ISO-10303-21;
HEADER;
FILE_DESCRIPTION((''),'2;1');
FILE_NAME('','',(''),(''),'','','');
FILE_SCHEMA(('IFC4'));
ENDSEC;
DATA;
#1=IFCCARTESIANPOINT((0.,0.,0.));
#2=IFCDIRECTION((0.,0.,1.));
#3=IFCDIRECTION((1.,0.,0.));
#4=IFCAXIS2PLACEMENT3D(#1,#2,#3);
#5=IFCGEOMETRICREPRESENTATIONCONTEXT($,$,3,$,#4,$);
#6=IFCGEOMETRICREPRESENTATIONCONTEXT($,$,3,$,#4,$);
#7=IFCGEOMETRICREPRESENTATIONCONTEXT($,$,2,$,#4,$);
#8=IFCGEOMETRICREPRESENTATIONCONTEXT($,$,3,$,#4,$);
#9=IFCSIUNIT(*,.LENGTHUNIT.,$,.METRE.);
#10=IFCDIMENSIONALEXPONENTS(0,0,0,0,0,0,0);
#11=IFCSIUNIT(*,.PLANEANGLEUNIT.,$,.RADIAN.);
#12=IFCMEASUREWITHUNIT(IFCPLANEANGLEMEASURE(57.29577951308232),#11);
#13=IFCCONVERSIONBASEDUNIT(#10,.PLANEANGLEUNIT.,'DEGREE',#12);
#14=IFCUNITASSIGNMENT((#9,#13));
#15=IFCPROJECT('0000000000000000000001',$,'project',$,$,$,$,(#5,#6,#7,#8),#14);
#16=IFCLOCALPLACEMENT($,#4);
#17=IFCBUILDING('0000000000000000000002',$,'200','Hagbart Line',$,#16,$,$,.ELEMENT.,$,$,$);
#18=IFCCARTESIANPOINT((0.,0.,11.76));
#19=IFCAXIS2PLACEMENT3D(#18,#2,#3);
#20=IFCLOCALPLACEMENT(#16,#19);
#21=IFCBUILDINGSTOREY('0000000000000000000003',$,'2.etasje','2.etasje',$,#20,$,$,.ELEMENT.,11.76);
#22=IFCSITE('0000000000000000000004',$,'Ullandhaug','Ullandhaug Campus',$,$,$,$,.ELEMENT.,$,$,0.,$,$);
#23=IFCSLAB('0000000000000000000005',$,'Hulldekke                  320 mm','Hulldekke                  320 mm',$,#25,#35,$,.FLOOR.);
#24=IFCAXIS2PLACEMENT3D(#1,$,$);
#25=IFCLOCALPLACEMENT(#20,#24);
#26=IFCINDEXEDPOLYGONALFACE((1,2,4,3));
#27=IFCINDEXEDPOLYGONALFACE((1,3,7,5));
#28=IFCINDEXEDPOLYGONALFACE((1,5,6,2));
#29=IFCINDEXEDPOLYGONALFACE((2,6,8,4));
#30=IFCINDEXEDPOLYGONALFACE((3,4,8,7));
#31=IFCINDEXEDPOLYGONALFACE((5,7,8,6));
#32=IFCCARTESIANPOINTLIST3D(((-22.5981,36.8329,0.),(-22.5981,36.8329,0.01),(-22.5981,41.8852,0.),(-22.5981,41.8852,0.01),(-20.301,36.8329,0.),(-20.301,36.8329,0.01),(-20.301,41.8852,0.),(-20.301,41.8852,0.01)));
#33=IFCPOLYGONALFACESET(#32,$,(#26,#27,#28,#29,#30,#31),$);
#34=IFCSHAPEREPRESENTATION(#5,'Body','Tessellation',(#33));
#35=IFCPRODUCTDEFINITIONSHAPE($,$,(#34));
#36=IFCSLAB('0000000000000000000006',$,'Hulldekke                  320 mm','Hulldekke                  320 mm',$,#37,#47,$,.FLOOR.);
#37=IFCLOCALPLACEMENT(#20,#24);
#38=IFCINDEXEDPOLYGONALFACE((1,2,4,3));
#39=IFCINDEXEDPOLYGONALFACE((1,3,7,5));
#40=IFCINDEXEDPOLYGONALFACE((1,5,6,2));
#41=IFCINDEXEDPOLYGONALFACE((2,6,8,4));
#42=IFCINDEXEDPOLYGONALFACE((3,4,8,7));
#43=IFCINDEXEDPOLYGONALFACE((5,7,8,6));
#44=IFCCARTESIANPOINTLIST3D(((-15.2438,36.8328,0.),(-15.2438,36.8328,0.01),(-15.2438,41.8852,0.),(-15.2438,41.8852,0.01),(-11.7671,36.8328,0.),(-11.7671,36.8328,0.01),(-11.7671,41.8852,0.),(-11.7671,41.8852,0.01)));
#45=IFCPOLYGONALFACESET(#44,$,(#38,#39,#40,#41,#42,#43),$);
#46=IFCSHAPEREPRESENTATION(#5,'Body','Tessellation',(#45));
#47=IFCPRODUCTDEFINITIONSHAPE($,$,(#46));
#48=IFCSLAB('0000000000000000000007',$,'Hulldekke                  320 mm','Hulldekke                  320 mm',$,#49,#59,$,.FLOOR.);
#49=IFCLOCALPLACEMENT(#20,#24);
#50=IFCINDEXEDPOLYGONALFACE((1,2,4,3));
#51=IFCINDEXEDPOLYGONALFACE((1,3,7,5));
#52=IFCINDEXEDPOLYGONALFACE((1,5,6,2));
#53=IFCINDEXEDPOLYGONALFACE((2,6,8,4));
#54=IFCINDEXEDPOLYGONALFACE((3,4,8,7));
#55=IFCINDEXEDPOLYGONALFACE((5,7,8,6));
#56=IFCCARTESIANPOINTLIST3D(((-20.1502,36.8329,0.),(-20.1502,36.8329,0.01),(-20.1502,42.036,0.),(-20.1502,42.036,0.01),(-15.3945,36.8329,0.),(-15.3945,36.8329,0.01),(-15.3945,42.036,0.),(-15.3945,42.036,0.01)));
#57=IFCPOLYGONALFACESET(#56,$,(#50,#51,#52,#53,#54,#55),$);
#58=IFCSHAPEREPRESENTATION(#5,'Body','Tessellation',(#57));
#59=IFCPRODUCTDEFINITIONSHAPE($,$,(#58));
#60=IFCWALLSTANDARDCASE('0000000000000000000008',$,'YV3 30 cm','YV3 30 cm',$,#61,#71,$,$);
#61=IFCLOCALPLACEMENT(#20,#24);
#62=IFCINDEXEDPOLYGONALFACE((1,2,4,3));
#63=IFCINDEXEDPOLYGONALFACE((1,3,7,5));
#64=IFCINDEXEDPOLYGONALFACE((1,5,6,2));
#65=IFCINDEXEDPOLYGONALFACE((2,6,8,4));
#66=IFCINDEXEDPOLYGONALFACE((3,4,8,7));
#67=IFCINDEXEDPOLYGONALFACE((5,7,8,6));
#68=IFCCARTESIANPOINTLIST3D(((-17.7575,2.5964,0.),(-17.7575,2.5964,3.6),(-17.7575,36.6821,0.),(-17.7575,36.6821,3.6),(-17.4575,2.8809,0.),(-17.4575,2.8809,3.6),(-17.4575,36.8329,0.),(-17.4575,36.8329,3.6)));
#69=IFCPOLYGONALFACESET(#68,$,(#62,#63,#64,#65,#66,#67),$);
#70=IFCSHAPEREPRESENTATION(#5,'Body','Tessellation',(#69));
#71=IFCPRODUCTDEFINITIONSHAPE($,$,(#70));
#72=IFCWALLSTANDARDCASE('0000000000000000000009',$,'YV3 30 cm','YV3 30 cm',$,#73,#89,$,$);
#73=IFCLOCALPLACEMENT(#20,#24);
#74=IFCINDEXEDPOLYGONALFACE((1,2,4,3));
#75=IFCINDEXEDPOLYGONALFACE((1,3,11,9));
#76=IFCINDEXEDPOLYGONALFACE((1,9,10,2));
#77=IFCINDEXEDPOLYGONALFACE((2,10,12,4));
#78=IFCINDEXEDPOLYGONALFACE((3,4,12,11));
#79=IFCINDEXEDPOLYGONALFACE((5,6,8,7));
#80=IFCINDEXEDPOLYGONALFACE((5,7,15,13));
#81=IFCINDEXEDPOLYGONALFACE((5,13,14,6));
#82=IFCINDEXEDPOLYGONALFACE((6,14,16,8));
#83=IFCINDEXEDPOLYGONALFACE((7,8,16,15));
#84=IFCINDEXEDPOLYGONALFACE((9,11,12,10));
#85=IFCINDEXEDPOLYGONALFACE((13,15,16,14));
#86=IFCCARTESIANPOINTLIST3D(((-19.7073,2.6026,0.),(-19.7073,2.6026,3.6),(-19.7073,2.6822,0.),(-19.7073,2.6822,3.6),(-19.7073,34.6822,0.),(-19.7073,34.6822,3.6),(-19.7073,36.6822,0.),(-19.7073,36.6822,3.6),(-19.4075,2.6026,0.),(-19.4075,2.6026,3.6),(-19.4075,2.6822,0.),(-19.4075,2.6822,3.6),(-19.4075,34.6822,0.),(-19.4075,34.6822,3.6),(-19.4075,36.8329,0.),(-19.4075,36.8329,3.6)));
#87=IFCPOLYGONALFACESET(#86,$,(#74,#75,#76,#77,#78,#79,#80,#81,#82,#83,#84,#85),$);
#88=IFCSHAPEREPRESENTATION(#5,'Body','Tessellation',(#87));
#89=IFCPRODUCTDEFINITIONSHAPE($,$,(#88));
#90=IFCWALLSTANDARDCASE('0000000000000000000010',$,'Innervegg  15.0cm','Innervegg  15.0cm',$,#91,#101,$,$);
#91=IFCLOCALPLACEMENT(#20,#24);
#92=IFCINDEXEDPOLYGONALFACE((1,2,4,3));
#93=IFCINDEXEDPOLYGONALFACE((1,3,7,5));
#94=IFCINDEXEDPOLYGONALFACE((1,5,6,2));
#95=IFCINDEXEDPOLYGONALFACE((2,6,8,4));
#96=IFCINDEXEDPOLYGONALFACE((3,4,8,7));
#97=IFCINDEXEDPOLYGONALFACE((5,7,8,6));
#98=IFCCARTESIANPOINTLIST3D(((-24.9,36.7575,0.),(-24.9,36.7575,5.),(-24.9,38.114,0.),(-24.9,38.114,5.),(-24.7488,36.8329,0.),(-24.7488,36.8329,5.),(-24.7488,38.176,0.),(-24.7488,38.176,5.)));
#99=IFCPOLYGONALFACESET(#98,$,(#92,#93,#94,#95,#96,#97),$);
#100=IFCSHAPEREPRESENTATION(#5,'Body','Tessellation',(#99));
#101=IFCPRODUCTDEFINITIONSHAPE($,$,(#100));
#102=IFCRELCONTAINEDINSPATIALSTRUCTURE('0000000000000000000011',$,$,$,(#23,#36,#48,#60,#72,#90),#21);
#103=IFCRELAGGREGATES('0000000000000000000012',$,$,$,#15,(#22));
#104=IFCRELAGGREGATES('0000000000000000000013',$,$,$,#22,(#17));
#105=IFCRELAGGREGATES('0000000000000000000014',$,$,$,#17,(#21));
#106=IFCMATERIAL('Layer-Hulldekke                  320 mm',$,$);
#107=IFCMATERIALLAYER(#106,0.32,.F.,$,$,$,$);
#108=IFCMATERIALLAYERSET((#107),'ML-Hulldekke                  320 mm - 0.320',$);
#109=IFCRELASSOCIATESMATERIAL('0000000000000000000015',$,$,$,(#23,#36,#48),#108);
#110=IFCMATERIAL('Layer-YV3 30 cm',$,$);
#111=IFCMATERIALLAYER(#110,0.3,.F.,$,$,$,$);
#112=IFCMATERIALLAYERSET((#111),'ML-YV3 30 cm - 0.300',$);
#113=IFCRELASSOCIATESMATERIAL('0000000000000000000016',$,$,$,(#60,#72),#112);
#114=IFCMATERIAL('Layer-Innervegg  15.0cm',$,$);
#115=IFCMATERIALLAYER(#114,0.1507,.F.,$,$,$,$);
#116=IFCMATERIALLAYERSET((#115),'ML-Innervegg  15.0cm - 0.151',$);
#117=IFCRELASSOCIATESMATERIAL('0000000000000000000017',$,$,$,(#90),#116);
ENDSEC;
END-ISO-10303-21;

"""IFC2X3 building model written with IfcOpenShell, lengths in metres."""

from ifc_helpers import new_model, entity, si_unit, converted_unit, frame, origin_with_axes, place, context, project, spatial, polyline, outline, extrude, material, layer, layer_set, layer_usage, element, save


model = new_model("IFC2X3")

# Units and contexts
context_of_model_1 = context(None, 3, world=origin_with_axes())
context_of_model_2 = context(None, 3, world=origin_with_axes())
context_of_model_3 = context(None, 2, world=origin_with_axes())
context_of_model_4 = context(None, 3, world=origin_with_axes())
ifc_project = project(units=[si_unit("LENGTHUNIT", "METRE"), converted_unit("PLANEANGLEUNIT", "DEGREE", entity("IfcPlaneAngleMeasure", 57.29577951308232), si_unit("PLANEANGLEUNIT", "RADIAN"), dimensions=[0, 0, 0, 0, 0, 0, 0])], contexts=[context_of_model_1, context_of_model_2, context_of_model_3, context_of_model_4])

# Site, building, storey
site = spatial("IfcSite", under=ifc_project, Name="Ullandhaug", Description="Ullandhaug Campus", CompositionType="ELEMENT", RefElevation=0.0)
building_placement = place(None, origin_with_axes())
building = spatial("IfcBuilding", under=site, at=building_placement, Name="200", Description="Hagbart Line", CompositionType="ELEMENT")
storey_placement = place(building_placement, frame((0.0, 0.0, 11.76), z_axis=(0.0, 0.0, 1.0), x_axis=(1.0, 0.0, 0.0)))
storey = spatial("IfcBuildingStorey", under=building, at=storey_placement, Name="2.etasje", Description="2.etasje", CompositionType="ELEMENT", Elevation=11.76)

# Slabs
ifc_material_1 = material(Name="Layer-Hulldekke                  320 mm")
ifc_layer_1 = layer(ifc_material_1, 0.32, ventilated=False)
ifc_layer_set_1 = layer_set([ifc_layer_1], Name="ML-Hulldekke                  320 mm - 0.320")
ifc_layer_usage_1 = layer_usage(ifc_layer_set_1, "AXIS2", "POSITIVE", 0.0)
slab_1_placement = place(storey_placement, frame((-22.5981, 36.8329, 0.0), z_axis=(0.0, 0.0, 1.0), x_axis=(1.0, 0.0, 0.0)))
element("IfcSlab", 1, at=slab_1_placement, inside=storey, material=ifc_layer_usage_1, Name="Hulldekke                  320 mm", Description="Hulldekke                  320 mm", PredefinedType="FLOOR", context=context_of_model_1, shape_type="SweptSolid", body=[
    extrude(outline(polyline([(0.0, 0.0), (2.2971, 0.0), (2.2971, 5.0523), (0.0, 5.0523), (0.0, 0.0)])), origin_with_axes(), (0.0, 0.0, 1.0), 0.01),
])
slab_2_placement = place(storey_placement, frame((-15.2438, 36.8328, 0.0), z_axis=(0.0, 0.0, 1.0), x_axis=(1.0, 0.0, 0.0)))
element("IfcSlab", 2, at=slab_2_placement, inside=storey, material=ifc_layer_usage_1, Name="Hulldekke                  320 mm", Description="Hulldekke                  320 mm", PredefinedType="FLOOR", context=context_of_model_1, shape_type="SweptSolid", body=[
    extrude(outline(polyline([(0.0, 0.0), (3.4766, 0.0), (3.4766, 5.0524), (0.0, 5.0524), (0.0, 0.0)])), origin_with_axes(), (0.0, 0.0, 1.0), 0.01),
])
slab_3_placement = place(storey_placement, frame((-20.1502, 36.8329, 0.0), z_axis=(0.0, 0.0, 1.0), x_axis=(1.0, 0.0, 0.0)))
element("IfcSlab", 3, at=slab_3_placement, inside=storey, material=ifc_layer_usage_1, Name="Hulldekke                  320 mm", Description="Hulldekke                  320 mm", PredefinedType="FLOOR", context=context_of_model_1, shape_type="SweptSolid", body=[
    extrude(outline(polyline([(0.0, 0.0), (4.7557, 0.0), (4.7557, 5.2031), (0.0, 5.2031), (0.0, 0.0)])), origin_with_axes(), (0.0, 0.0, 1.0), 0.01),
])

# Wall
ifc_material_2 = material(Name="Layer-YV3 30 cm")
ifc_layer_2 = layer(ifc_material_2, 0.3, ventilated=False)
ifc_layer_set_2 = layer_set([ifc_layer_2], Name="ML-YV3 30 cm - 0.300")
ifc_layer_usage_2 = layer_usage(ifc_layer_set_2, "AXIS2", "POSITIVE", 0.0)
wall_1_placement = place(storey_placement, frame((-17.7575, 36.6821, 0.0), z_axis=(0.0, 0.0, 1.0), x_axis=(0.0, -1.0, 0.0)))
element("IfcWallStandardCase", 4, at=wall_1_placement, inside=storey, material=ifc_layer_usage_2, Name="YV3 30 cm", Description="YV3 30 cm", context=context_of_model_1, shape_type="SweptSolid", body=[
    extrude(outline(polyline([(0.0, 0.0), (34.0857, 0.0), (33.8012, 0.3), (-0.1507, 0.3), (0.0, 0.0)])), frame((0.0, 0.0, 0.0), z_axis=(0.0, 0.0, 1.0), x_axis=(1.0, 0.0, 0.0)), (0.0, 0.0, 1.0), 3.6),
])

# Wall, openings
wall_2_placement = place(storey_placement, frame((-19.7073, 36.6822, 0.0), z_axis=(0.0, 0.0, 1.0), x_axis=(0.0, -1.0, 0.0)))
wall_2 = element("IfcWallStandardCase", 5, at=wall_2_placement, inside=storey, material=ifc_layer_usage_2, Name="YV3 30 cm", Description="YV3 30 cm", context=context_of_model_1, shape_type="SweptSolid", body=[
    extrude(outline(polyline([(0.0, 0.0), (34.0796, 0.0), (34.0796, 0.2999), (-0.1507, 0.2999), (0.0, 0.0)])), frame((0.0, 0.0, 0.0), z_axis=(0.0, 0.0, 1.0), x_axis=(1.0, 0.0, 0.0)), (0.0, 0.0, 1.0), 3.6),
])
opening_1_placement = place(wall_2_placement, frame((2.0, 0.2999, 0.0), z_axis=(0.0, 0.0, 1.0), x_axis=(1.0, 0.0, 0.0)))
element("IfcOpeningElement", 6, at=opening_1_placement, cuts=wall_2, context=context_of_model_1, shape_type="SweptSolid", body=[
    extrude(outline(polyline([(0.0, 0.0), (3.6, 0.0), (3.6, 2.0), (0.0, 2.0), (0.0, 0.0)])), frame((0.0, 0.0, 0.0), z_axis=(0.0, 1.0, 0.0), x_axis=(0.0, 0.0, 1.0)), (0.0, 0.0, -1.0), 0.3),
])
opening_2_placement = place(wall_2_placement, frame((4.0, 0.2999, 0.0), z_axis=(0.0, 0.0, 1.0), x_axis=(1.0, 0.0, 0.0)))
element("IfcOpeningElement", 7, at=opening_2_placement, cuts=wall_2, context=context_of_model_1, shape_type="SweptSolid", body=[
    extrude(outline(polyline([(0.0, 0.0), (3.6, 0.0), (3.6, 2.0), (0.0, 2.0), (0.0, 0.0)])), frame((0.0, 0.0, 0.0), z_axis=(0.0, 1.0, 0.0), x_axis=(0.0, 0.0, 1.0)), (0.0, 0.0, -1.0), 0.3),
])
opening_3_placement = place(wall_2_placement, frame((6.0, 0.2999, 0.0), z_axis=(0.0, 0.0, 1.0), x_axis=(1.0, 0.0, 0.0)))
element("IfcOpeningElement", 8, at=opening_3_placement, cuts=wall_2, context=context_of_model_1, shape_type="SweptSolid", body=[
    extrude(outline(polyline([(0.0, 0.0), (3.6, 0.0), (3.6, 2.0), (0.0, 2.0), (0.0, 0.0)])), frame((0.0, 0.0, 0.0), z_axis=(0.0, 1.0, 0.0), x_axis=(0.0, 0.0, 1.0)), (0.0, 0.0, -1.0), 0.3),
])
opening_4_placement = place(wall_2_placement, frame((8.0, 0.2999, 0.0), z_axis=(0.0, 0.0, 1.0), x_axis=(1.0, 0.0, 0.0)))
element("IfcOpeningElement", 9, at=opening_4_placement, cuts=wall_2, context=context_of_model_1, shape_type="SweptSolid", body=[
    extrude(outline(polyline([(0.0, 0.0), (3.6, 0.0), (3.6, 2.0), (0.0, 2.0), (0.0, 0.0)])), frame((0.0, 0.0, 0.0), z_axis=(0.0, 1.0, 0.0), x_axis=(0.0, 0.0, 1.0)), (0.0, 0.0, -1.0), 0.3),
])
opening_5_placement = place(wall_2_placement, frame((10.0, 0.2999, 0.0), z_axis=(0.0, 0.0, 1.0), x_axis=(1.0, 0.0, 0.0)))
element("IfcOpeningElement", 10, at=opening_5_placement, cuts=wall_2, context=context_of_model_1, shape_type="SweptSolid", body=[
    extrude(outline(polyline([(0.0, 0.0), (3.6, 0.0), (3.6, 2.0), (0.0, 2.0), (0.0, 0.0)])), frame((0.0, 0.0, 0.0), z_axis=(0.0, 1.0, 0.0), x_axis=(0.0, 0.0, 1.0)), (0.0, 0.0, -1.0), 0.3),
])
opening_6_placement = place(wall_2_placement, frame((12.0, 0.2999, 0.0), z_axis=(0.0, 0.0, 1.0), x_axis=(1.0, 0.0, 0.0)))
element("IfcOpeningElement", 11, at=opening_6_placement, cuts=wall_2, context=context_of_model_1, shape_type="SweptSolid", body=[
    extrude(outline(polyline([(0.0, 0.0), (3.6, 0.0), (3.6, 2.0), (0.0, 2.0), (0.0, 0.0)])), frame((0.0, 0.0, 0.0), z_axis=(0.0, 1.0, 0.0), x_axis=(0.0, 0.0, 1.0)), (0.0, 0.0, -1.0), 0.3),
])
opening_7_placement = place(wall_2_placement, frame((14.0, 0.2999, 0.0), z_axis=(0.0, 0.0, 1.0), x_axis=(1.0, 0.0, 0.0)))
element("IfcOpeningElement", 12, at=opening_7_placement, cuts=wall_2, context=context_of_model_1, shape_type="SweptSolid", body=[
    extrude(outline(polyline([(0.0, 0.0), (3.6, 0.0), (3.6, 2.0), (0.0, 2.0), (0.0, 0.0)])), frame((0.0, 0.0, 0.0), z_axis=(0.0, 1.0, 0.0), x_axis=(0.0, 0.0, 1.0)), (0.0, 0.0, -1.0), 0.3),
])
opening_8_placement = place(wall_2_placement, frame((16.0, 0.2999, 0.0), z_axis=(0.0, 0.0, 1.0), x_axis=(1.0, 0.0, 0.0)))
element("IfcOpeningElement", 13, at=opening_8_placement, cuts=wall_2, context=context_of_model_1, shape_type="SweptSolid", body=[
    extrude(outline(polyline([(0.0, 0.0), (3.6, 0.0), (3.6, 2.0), (0.0, 2.0), (0.0, 0.0)])), frame((0.0, 0.0, 0.0), z_axis=(0.0, 1.0, 0.0), x_axis=(0.0, 0.0, 1.0)), (0.0, 0.0, -1.0), 0.3),
])
opening_9_placement = place(wall_2_placement, frame((18.0, 0.2999, 0.0), z_axis=(0.0, 0.0, 1.0), x_axis=(1.0, 0.0, 0.0)))
element("IfcOpeningElement", 14, at=opening_9_placement, cuts=wall_2, context=context_of_model_1, shape_type="SweptSolid", body=[
    extrude(outline(polyline([(0.0, 0.0), (3.6, 0.0), (3.6, 2.0), (0.0, 2.0), (0.0, 0.0)])), frame((0.0, 0.0, 0.0), z_axis=(0.0, 1.0, 0.0), x_axis=(0.0, 0.0, 1.0)), (0.0, 0.0, -1.0), 0.3),
])
opening_10_placement = place(wall_2_placement, frame((20.0, 0.2999, 0.0), z_axis=(0.0, 0.0, 1.0), x_axis=(1.0, 0.0, 0.0)))
element("IfcOpeningElement", 15, at=opening_10_placement, cuts=wall_2, context=context_of_model_1, shape_type="SweptSolid", body=[
    extrude(outline(polyline([(0.0, 0.0), (3.6, 0.0), (3.6, 2.0), (0.0, 2.0), (0.0, 0.0)])), frame((0.0, 0.0, 0.0), z_axis=(0.0, 1.0, 0.0), x_axis=(0.0, 0.0, 1.0)), (0.0, 0.0, -1.0), 0.3),
])
opening_11_placement = place(wall_2_placement, frame((22.0, 0.2999, 0.0), z_axis=(0.0, 0.0, 1.0), x_axis=(1.0, 0.0, 0.0)))
element("IfcOpeningElement", 16, at=opening_11_placement, cuts=wall_2, context=context_of_model_1, shape_type="SweptSolid", body=[
    extrude(outline(polyline([(0.0, 0.0), (3.6, 0.0), (3.6, 2.0), (0.0, 2.0), (0.0, 0.0)])), frame((0.0, 0.0, 0.0), z_axis=(0.0, 1.0, 0.0), x_axis=(0.0, 0.0, 1.0)), (0.0, 0.0, -1.0), 0.3),
])
opening_12_placement = place(wall_2_placement, frame((24.0, 0.2999, 0.0), z_axis=(0.0, 0.0, 1.0), x_axis=(1.0, 0.0, 0.0)))
element("IfcOpeningElement", 17, at=opening_12_placement, cuts=wall_2, context=context_of_model_1, shape_type="SweptSolid", body=[
    extrude(outline(polyline([(0.0, 0.0), (3.6, 0.0), (3.6, 2.0), (0.0, 2.0), (0.0, 0.0)])), frame((0.0, 0.0, 0.0), z_axis=(0.0, 1.0, 0.0), x_axis=(0.0, 0.0, 1.0)), (0.0, 0.0, -1.0), 0.3),
])
opening_13_placement = place(wall_2_placement, frame((26.0, 0.2999, 0.0), z_axis=(0.0, 0.0, 1.0), x_axis=(1.0, 0.0, 0.0)))
element("IfcOpeningElement", 18, at=opening_13_placement, cuts=wall_2, context=context_of_model_1, shape_type="SweptSolid", body=[
    extrude(outline(polyline([(0.0, 0.0), (3.6, 0.0), (3.6, 2.0), (0.0, 2.0), (0.0, 0.0)])), frame((0.0, 0.0, 0.0), z_axis=(0.0, 1.0, 0.0), x_axis=(0.0, 0.0, 1.0)), (0.0, 0.0, -1.0), 0.3),
])
opening_14_placement = place(wall_2_placement, frame((28.0, 0.2999, 0.0), z_axis=(0.0, 0.0, 1.0), x_axis=(1.0, 0.0, 0.0)))
element("IfcOpeningElement", 19, at=opening_14_placement, cuts=wall_2, context=context_of_model_1, shape_type="SweptSolid", body=[
    extrude(outline(polyline([(0.0, 0.0), (3.6, 0.0), (3.6, 2.0), (0.0, 2.0), (0.0, 0.0)])), frame((0.0, 0.0, 0.0), z_axis=(0.0, 1.0, 0.0), x_axis=(0.0, 0.0, 1.0)), (0.0, 0.0, -1.0), 0.3),
])
opening_15_placement = place(wall_2_placement, frame((30.0, 0.2999, 0.0), z_axis=(0.0, 0.0, 1.0), x_axis=(1.0, 0.0, 0.0)))
element("IfcOpeningElement", 20, at=opening_15_placement, cuts=wall_2, context=context_of_model_1, shape_type="SweptSolid", body=[
    extrude(outline(polyline([(0.0, 0.0), (3.6, 0.0), (3.6, 2.0), (0.0, 2.0), (0.0, 0.0)])), frame((0.0, 0.0, 0.0), z_axis=(0.0, 1.0, 0.0), x_axis=(0.0, 0.0, 1.0)), (0.0, 0.0, -1.0), 0.3),
])
opening_16_placement = place(wall_2_placement, frame((32.0, 0.2999, 0.0), z_axis=(0.0, 0.0, 1.0), x_axis=(1.0, 0.0, 0.0)))
element("IfcOpeningElement", 21, at=opening_16_placement, cuts=wall_2, context=context_of_model_1, shape_type="SweptSolid", body=[
    extrude(outline(polyline([(0.0, 0.0), (3.6, 0.0), (3.6, 2.0), (0.0, 2.0), (0.0, 0.0)])), frame((0.0, 0.0, 0.0), z_axis=(0.0, 1.0, 0.0), x_axis=(0.0, 0.0, 1.0)), (0.0, 0.0, -1.0), 0.3),
])

# Wall
ifc_material_3 = material(Name="Layer-Innervegg  15.0cm")
ifc_layer_3 = layer(ifc_material_3, 0.1507, ventilated=False)
ifc_layer_set_3 = layer_set([ifc_layer_3], Name="ML-Innervegg  15.0cm - 0.151")
ifc_layer_usage_3 = layer_usage(ifc_layer_set_3, "AXIS2", "POSITIVE", 0.0)
wall_3_placement = place(storey_placement, frame((-24.7488, 36.8329, 0.0), z_axis=(0.0, 0.0, 1.0), x_axis=(0.0, 1.0, 0.0)))
element("IfcWallStandardCase", 22, at=wall_3_placement, inside=storey, material=ifc_layer_usage_3, Name="Innervegg  15.0cm", Description="Innervegg  15.0cm", context=context_of_model_1, shape_type="SweptSolid", body=[
    extrude(outline(polyline([(0.0, 0.0), (1.3431, 0.0), (1.2811, 0.1512), (-0.0754, 0.1512), (0.0, 0.0)])), frame((0.0, 0.0, 0.0), z_axis=(0.0, 0.0, 1.0), x_axis=(1.0, 0.0, 0.0)), (0.0, 0.0, 1.0), 5.0),
])

save(model, "model.ifc")
